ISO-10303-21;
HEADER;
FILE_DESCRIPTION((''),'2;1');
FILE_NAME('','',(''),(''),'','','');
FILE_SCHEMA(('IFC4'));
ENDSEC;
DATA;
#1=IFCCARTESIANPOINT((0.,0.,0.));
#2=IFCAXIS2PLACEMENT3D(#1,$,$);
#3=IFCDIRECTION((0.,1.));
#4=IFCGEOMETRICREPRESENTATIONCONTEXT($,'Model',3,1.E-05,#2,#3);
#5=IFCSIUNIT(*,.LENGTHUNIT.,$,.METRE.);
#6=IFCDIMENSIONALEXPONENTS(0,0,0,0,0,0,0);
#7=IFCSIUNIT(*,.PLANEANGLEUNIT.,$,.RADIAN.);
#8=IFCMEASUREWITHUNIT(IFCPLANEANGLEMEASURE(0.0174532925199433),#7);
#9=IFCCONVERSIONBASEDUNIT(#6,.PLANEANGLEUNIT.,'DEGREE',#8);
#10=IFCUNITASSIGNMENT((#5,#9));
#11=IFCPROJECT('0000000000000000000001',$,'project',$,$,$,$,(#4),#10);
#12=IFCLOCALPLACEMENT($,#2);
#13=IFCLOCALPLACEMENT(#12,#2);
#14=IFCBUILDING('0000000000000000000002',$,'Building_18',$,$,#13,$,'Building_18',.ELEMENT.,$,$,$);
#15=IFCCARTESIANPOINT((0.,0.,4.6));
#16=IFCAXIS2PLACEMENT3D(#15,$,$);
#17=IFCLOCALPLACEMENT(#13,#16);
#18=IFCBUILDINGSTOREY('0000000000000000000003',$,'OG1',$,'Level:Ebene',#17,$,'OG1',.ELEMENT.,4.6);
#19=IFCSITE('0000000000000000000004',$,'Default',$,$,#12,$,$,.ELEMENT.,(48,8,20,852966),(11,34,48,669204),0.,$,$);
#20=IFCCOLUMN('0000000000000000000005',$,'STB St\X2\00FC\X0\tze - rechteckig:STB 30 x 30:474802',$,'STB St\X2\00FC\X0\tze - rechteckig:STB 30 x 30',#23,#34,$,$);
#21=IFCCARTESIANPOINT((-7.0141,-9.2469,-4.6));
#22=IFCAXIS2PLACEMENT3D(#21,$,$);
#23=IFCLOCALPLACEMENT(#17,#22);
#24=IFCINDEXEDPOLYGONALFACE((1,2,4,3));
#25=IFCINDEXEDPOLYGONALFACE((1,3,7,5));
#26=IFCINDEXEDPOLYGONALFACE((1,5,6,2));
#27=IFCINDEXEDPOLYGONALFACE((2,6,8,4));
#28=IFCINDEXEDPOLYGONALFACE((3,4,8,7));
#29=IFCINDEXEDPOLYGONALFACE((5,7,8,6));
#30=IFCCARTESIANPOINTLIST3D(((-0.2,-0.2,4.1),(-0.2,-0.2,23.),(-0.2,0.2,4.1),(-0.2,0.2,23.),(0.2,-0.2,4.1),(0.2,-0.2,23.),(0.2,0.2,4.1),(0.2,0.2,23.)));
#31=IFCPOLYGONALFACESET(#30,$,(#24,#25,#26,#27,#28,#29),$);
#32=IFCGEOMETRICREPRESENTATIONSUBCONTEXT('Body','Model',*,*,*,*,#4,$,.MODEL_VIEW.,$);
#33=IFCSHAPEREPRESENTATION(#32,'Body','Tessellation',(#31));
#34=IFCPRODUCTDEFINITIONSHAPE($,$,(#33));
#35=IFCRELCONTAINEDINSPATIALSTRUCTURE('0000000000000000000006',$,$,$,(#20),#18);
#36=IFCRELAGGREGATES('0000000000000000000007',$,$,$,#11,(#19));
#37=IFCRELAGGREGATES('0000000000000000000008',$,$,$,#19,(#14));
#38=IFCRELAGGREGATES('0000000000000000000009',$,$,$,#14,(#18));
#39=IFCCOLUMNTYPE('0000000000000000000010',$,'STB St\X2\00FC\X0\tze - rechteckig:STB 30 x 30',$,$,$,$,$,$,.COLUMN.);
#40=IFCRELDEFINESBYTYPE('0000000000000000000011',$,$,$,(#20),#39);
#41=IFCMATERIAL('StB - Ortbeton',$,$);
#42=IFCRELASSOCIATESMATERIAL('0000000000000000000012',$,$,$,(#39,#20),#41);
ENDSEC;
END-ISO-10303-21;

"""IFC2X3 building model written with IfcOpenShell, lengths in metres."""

from ifc_helpers import new_model, entity, si_unit, converted_unit, direction, frame, origin, origin_2d_with_axis, place, context, subcontext, project, spatial, rectangle, extrude, source, transform, mapped, material, type_object, type_shapes, element, save


model = new_model("IFC2X3")

# Units and contexts
model_context = context("Model", 3, precision=1e-05, world=origin(), true_north=direction((0.0, 1.0)))
body_context = subcontext(model_context, "Body", "Model", "MODEL_VIEW")
ifc_project = project(units=[si_unit("LENGTHUNIT", "METRE"), converted_unit("PLANEANGLEUNIT", "DEGREE", entity("IfcPlaneAngleMeasure", 0.0174532925199433), si_unit("PLANEANGLEUNIT", "RADIAN"), dimensions=[0, 0, 0, 0, 0, 0, 0])], contexts=[model_context])

# Site, building, storey
site_placement = place(None, origin())
site = spatial("IfcSite", under=ifc_project, at=site_placement, Name="Default", CompositionType="ELEMENT", RefLatitude=(48, 8, 20, 852966), RefLongitude=(11, 34, 48, 669204), RefElevation=0.0)
building_placement = place(site_placement, origin())
building = spatial("IfcBuilding", under=site, at=building_placement, Name="Building_18", LongName="Building_18", CompositionType="ELEMENT")
storey_placement = place(building_placement, frame((0.0, 0.0, 4.6)))
storey = spatial("IfcBuildingStorey", under=building, at=storey_placement, Name="OG1", ObjectType="Level:Ebene", LongName="OG1", CompositionType="ELEMENT", Elevation=4.6)

# Column
ifc_material_1 = material(Name="StB - Ortbeton")
column_type = type_object("IfcColumnType", Name="STB Stütze - rechteckig:STB 30 x 30", PredefinedType="COLUMN", material=ifc_material_1)
shared_shape_1 = source(origin(), body_context, "Body", "SweptSolid", [
    extrude(rectangle(XDim=0.4, YDim=0.4, at=origin_2d_with_axis()), frame((0.0, 0.0, 4.1), z_axis=(0.0, 0.0, 1.0), x_axis=(-1.0, 0.0, 0.0)), (0.0, 0.0, 1.0), 18.9),
])
type_shapes(column_type, [shared_shape_1])
column_placement = place(storey_placement, frame((-7.0141, -9.2469, -4.6)))
element("IfcColumn", 1, at=column_placement, inside=storey, type_object=column_type, material=ifc_material_1, Name="STB Stütze - rechteckig:STB 30 x 30:474802", ObjectType="STB Stütze - rechteckig:STB 30 x 30", context=body_context, shape_type="MappedRepresentation", body=[
    mapped(shared_shape_1, transform((0.0, 0.0, 0.0), scale=1.0)),
])

save(model, "model.ifc")
